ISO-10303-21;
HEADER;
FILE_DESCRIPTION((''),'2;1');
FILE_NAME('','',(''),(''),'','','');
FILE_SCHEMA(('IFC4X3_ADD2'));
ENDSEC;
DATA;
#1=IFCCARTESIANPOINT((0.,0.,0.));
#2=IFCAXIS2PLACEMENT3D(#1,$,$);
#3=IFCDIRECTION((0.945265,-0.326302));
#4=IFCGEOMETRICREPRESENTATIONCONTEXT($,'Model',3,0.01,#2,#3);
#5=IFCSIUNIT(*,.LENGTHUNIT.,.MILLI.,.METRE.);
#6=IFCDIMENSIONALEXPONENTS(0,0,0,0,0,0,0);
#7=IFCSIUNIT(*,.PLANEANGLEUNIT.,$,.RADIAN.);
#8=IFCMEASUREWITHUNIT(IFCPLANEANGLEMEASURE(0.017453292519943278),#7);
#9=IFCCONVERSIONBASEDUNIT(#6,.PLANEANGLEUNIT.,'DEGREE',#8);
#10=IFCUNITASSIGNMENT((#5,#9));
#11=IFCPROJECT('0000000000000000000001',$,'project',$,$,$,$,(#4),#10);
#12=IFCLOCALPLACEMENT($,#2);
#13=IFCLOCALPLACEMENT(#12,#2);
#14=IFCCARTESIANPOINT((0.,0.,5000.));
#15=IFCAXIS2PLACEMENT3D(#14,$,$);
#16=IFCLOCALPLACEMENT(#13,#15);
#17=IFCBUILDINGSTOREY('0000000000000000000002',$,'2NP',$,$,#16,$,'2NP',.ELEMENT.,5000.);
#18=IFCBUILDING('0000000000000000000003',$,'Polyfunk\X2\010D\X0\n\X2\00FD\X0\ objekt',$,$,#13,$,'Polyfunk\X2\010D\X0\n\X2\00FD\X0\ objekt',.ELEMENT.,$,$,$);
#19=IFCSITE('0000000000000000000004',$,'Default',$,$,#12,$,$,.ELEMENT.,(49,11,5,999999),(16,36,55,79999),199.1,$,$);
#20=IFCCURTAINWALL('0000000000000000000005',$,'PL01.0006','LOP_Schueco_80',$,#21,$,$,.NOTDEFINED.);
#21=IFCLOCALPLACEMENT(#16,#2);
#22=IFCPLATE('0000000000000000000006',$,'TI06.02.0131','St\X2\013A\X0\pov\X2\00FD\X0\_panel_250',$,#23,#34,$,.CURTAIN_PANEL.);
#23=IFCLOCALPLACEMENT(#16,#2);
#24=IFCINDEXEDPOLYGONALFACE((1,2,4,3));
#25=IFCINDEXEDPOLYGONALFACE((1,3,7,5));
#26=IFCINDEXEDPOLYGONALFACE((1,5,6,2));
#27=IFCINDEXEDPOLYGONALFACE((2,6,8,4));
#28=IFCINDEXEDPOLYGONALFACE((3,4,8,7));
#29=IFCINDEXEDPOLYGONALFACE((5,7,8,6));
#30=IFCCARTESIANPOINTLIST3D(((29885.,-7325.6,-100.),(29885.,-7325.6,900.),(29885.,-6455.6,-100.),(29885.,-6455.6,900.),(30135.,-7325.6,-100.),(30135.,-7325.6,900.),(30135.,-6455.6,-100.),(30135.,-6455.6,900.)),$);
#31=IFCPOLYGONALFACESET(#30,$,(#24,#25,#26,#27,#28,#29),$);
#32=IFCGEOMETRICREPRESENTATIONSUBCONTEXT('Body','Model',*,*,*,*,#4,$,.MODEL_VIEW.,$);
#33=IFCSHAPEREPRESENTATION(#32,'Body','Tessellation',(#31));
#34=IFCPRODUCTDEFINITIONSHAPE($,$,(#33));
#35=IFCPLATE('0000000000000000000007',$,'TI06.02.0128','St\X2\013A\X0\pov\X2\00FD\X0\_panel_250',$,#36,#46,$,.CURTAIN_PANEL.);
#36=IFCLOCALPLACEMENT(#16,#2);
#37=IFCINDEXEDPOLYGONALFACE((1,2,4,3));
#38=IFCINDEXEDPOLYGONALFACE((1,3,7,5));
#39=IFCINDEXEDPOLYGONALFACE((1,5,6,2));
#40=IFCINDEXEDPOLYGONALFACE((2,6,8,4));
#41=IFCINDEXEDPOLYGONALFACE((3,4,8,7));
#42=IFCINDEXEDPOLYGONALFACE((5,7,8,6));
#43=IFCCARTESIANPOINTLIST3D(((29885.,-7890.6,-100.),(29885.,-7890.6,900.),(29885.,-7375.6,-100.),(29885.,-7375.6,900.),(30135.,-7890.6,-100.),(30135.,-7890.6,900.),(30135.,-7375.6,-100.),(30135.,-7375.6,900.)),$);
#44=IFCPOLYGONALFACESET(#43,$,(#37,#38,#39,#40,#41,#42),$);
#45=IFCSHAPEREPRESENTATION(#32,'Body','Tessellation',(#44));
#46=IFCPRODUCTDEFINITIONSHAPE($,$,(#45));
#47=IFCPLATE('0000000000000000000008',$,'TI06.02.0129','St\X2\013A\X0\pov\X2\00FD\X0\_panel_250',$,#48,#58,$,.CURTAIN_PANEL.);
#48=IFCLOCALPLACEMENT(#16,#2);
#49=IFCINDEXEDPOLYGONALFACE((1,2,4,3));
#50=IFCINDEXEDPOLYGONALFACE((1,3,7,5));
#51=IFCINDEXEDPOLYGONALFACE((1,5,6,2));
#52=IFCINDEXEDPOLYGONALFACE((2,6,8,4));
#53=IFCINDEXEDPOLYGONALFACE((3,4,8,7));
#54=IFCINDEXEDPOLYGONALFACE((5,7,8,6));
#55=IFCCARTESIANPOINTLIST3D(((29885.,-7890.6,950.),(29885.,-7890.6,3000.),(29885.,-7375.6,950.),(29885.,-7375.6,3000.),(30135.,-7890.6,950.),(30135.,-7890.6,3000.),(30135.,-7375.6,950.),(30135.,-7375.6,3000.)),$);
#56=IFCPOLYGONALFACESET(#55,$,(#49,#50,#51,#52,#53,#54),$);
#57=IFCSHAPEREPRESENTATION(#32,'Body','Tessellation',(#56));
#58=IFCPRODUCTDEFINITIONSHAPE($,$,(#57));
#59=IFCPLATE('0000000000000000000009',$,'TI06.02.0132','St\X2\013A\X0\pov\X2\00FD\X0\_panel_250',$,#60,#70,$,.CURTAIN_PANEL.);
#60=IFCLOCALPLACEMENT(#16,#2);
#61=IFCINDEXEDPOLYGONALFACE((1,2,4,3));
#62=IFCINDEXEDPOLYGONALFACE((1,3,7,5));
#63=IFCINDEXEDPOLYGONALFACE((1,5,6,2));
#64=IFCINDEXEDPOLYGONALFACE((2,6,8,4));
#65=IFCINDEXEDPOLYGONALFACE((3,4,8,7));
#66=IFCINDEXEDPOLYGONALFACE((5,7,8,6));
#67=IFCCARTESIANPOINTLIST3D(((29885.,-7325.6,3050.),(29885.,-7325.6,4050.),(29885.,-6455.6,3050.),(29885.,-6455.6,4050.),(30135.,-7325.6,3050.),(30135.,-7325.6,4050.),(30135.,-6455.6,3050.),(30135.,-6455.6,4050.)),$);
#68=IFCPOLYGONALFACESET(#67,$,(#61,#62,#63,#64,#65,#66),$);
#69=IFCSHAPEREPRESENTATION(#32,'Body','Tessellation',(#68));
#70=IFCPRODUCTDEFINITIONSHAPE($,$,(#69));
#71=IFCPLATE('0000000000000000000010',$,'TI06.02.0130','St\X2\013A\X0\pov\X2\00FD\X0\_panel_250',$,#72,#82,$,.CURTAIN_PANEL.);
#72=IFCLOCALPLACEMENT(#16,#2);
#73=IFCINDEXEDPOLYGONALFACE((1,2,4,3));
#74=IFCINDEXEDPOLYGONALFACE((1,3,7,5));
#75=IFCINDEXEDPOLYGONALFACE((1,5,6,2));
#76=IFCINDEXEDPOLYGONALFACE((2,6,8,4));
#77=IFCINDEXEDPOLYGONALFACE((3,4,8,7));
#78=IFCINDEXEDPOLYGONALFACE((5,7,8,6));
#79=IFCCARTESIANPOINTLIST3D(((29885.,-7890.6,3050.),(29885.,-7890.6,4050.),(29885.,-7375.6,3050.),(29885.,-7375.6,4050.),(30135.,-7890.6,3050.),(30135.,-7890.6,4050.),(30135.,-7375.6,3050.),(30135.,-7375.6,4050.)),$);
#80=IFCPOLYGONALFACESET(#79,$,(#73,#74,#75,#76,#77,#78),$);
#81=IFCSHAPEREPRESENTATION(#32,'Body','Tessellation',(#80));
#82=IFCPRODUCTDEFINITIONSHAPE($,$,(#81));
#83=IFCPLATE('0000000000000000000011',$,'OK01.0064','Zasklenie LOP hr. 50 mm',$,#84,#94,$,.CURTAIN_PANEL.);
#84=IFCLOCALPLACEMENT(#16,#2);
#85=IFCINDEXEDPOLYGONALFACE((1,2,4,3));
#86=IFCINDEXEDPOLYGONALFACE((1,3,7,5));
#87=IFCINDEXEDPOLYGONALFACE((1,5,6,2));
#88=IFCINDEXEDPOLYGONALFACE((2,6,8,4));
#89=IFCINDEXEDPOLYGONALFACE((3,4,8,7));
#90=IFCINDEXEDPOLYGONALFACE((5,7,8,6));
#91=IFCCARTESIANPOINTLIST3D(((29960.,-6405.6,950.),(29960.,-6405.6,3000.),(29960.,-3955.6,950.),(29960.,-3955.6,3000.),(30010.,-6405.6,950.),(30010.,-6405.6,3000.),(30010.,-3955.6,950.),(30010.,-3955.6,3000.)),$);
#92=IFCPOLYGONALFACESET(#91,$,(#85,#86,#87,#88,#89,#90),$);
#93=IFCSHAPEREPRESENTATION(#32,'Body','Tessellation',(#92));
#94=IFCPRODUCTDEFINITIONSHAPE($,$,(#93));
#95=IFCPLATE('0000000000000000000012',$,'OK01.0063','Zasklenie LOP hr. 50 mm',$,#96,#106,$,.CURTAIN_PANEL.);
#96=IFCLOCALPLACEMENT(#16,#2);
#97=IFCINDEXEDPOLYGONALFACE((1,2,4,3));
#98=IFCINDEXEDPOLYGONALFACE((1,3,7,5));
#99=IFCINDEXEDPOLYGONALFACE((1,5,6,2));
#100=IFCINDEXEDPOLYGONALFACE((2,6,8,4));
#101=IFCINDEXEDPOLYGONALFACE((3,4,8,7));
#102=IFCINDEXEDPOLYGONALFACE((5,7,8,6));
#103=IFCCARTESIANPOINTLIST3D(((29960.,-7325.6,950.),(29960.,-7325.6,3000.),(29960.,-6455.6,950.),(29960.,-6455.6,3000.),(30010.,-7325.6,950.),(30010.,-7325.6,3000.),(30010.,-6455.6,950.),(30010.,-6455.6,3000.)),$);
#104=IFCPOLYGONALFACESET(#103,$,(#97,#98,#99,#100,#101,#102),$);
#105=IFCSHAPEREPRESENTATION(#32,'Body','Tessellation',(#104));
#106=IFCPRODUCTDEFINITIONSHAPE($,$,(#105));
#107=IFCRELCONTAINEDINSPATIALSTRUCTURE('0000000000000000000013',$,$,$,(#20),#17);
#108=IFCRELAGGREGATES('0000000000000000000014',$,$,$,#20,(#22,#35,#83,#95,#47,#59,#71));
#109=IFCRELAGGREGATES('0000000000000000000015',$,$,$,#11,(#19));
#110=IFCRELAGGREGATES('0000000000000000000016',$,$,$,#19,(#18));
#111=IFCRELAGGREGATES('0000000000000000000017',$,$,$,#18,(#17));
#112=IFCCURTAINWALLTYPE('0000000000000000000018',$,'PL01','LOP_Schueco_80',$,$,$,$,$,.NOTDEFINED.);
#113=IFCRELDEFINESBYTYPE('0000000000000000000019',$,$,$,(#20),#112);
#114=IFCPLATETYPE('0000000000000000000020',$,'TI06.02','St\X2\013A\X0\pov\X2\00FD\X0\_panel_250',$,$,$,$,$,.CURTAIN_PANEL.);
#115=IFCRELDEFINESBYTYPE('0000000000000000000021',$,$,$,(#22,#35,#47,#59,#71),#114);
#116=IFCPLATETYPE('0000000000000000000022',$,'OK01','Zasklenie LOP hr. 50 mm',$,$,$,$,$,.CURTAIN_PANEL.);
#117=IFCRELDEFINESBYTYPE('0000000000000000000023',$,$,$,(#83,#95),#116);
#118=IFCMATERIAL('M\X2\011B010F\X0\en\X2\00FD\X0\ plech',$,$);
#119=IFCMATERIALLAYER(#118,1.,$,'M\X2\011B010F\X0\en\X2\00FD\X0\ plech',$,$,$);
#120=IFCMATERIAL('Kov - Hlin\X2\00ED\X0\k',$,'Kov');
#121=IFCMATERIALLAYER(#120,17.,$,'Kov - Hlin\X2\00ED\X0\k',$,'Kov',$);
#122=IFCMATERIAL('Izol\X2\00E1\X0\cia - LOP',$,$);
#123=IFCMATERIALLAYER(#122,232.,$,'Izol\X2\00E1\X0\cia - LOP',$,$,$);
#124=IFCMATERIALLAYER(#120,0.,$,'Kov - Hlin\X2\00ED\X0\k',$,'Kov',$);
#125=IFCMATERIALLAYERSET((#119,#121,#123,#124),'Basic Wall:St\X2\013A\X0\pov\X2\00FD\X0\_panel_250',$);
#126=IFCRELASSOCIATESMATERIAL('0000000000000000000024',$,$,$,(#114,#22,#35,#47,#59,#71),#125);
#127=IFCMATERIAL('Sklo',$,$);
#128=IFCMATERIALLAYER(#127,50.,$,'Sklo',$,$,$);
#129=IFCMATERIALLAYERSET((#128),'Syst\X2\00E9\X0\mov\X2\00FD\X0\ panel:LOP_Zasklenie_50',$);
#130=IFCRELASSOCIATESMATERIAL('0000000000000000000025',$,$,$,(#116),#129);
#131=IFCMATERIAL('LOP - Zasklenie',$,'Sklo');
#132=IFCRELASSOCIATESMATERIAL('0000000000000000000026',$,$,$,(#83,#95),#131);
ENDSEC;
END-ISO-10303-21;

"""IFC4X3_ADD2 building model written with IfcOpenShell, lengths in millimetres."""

from ifc_helpers import new_model, entity, si_unit, converted_unit, direction, frame, frame_2d, origin, origin_2d_with_axis, place, context, subcontext, project, spatial, rectangle, extrude, source, transform, mapped, material, layer, layer_set, layer_usage, type_object, type_shapes, element, aggregate, save


model = new_model("IFC4X3_ADD2")

# Units and contexts
model_context = context("Model", 3, precision=0.01, world=origin(), true_north=direction((0.945265, -0.326302)))
body_context = subcontext(model_context, "Body", "Model", "MODEL_VIEW")
ifc_project = project(units=[si_unit("LENGTHUNIT", "METRE", prefix="MILLI"), converted_unit("PLANEANGLEUNIT", "DEGREE", entity("IfcPlaneAngleMeasure", 0.017453292519943278), si_unit("PLANEANGLEUNIT", "RADIAN"), dimensions=[0, 0, 0, 0, 0, 0, 0])], contexts=[model_context])

# Site, building, storey
site_placement = place(None, origin())
site = spatial("IfcSite", under=ifc_project, at=site_placement, Name="Default", CompositionType="ELEMENT", RefLatitude=(49, 11, 5, 999999), RefLongitude=(16, 36, 55, 79999), RefElevation=199.1)
building_placement = place(site_placement, origin())
building = spatial("IfcBuilding", under=site, at=building_placement, Name="Polyfunkčný objekt", LongName="Polyfunkčný objekt", CompositionType="ELEMENT")
storey_placement = place(building_placement, frame((0.0, 0.0, 5000.0)))
storey = spatial("IfcBuildingStorey", under=building, at=storey_placement, Name="2NP", LongName="2NP", CompositionType="ELEMENT", Elevation=5000.0)

# Curtain wall, plates
curtain_wall_type = type_object("IfcCurtainWallType", Name="PL01", Description="LOP_Schueco_80", PredefinedType="NOTDEFINED")
curtain_wall_placement = place(storey_placement, frame((0.0, 0.0, -5000.0)))
curtain_wall = element("IfcCurtainWall", 1, at=curtain_wall_placement, inside=storey, type_object=curtain_wall_type, Name="PL01.0006", Description="LOP_Schueco_80", PredefinedType="NOTDEFINED")
ifc_material_1 = material(Name="Měďený plech")
ifc_layer_1 = layer(ifc_material_1, 1.0, Name="Měďený plech")
ifc_material_2 = material(Name="Kov - Hliník", Category="Kov")
ifc_layer_2 = layer(ifc_material_2, 17.0, Name="Kov - Hliník", Category="Kov")
ifc_material_3 = material(Name="Izolácia - LOP")
ifc_layer_3 = layer(ifc_material_3, 232.0, Name="Izolácia - LOP")
ifc_layer_4 = layer(ifc_material_2, 0.0, Name="Kov - Hliník", Category="Kov")
ifc_layer_set_1 = layer_set([ifc_layer_1, ifc_layer_2, ifc_layer_3, ifc_layer_4], Name="Basic Wall:Stĺpový_panel_250")
ifc_layer_usage_1 = layer_usage(ifc_layer_set_1, "AXIS2", "POSITIVE", -125.0)
plate_type_1 = type_object("IfcPlateType", Name="TI06.02", Description="Stĺpový_panel_250", PredefinedType="CURTAIN_PANEL", material=ifc_layer_set_1)
plate_1_placement = place(storey_placement, frame((30010.0, -6455.6, -100.0), z_axis=(0.0, 0.0, 1.0), x_axis=(0.0, -1.0, 0.0)))
plate_1 = element("IfcPlate", 2, at=plate_1_placement, type_object=plate_type_1, material=ifc_layer_usage_1, Name="TI06.02.0131", Description="Stĺpový_panel_250", PredefinedType="CURTAIN_PANEL", context=body_context, shape_type="SweptSolid", body=[
    extrude(rectangle(XDim=250.0, YDim=870.0, at=frame_2d((0.0, 0.0), x_axis=(1.0, 0.0))), frame((435.0, 0.0, 0.0), z_axis=(0.0, 0.0, 1.0), x_axis=(0.0, 1.0, 0.0)), (0.0, 0.0, 1.0), 1000.0),
])
ifc_layer_usage_2 = layer_usage(ifc_layer_set_1, "AXIS2", "POSITIVE", -125.0)
plate_2_placement = place(storey_placement, frame((30010.0, -7375.6, -100.0), z_axis=(0.0, 0.0, 1.0), x_axis=(0.0, -1.0, 0.0)))
plate_2 = element("IfcPlate", 3, at=plate_2_placement, type_object=plate_type_1, material=ifc_layer_usage_2, Name="TI06.02.0128", Description="Stĺpový_panel_250", PredefinedType="CURTAIN_PANEL", context=body_context, shape_type="SweptSolid", body=[
    extrude(rectangle(XDim=250.0, YDim=515.0, at=frame_2d((0.0, 0.0), x_axis=(1.0, 0.0))), frame((257.5, 0.0, 0.0), z_axis=(0.0, 0.0, 1.0), x_axis=(0.0, 1.0, 0.0)), (0.0, 0.0, 1.0), 1000.0),
])
ifc_layer_usage_3 = layer_usage(ifc_layer_set_1, "AXIS2", "POSITIVE", -125.0)
plate_3_placement = place(storey_placement, frame((30010.0, -7375.6, 950.0), z_axis=(0.0, 0.0, 1.0), x_axis=(0.0, -1.0, 0.0)))
plate_3 = element("IfcPlate", 4, at=plate_3_placement, type_object=plate_type_1, material=ifc_layer_usage_3, Name="TI06.02.0129", Description="Stĺpový_panel_250", PredefinedType="CURTAIN_PANEL", context=body_context, shape_type="SweptSolid", body=[
    extrude(rectangle(XDim=250.0, YDim=515.0, at=frame_2d((0.0, 0.0), x_axis=(1.0, 0.0))), frame((257.5, 0.0, 0.0), z_axis=(0.0, 0.0, 1.0), x_axis=(0.0, 1.0, 0.0)), (0.0, 0.0, 1.0), 2050.0),
])
ifc_layer_usage_4 = layer_usage(ifc_layer_set_1, "AXIS2", "POSITIVE", -125.0)
plate_4_placement = place(storey_placement, frame((30010.0, -6455.6, 3050.0), z_axis=(0.0, 0.0, 1.0), x_axis=(0.0, -1.0, 0.0)))
plate_4 = element("IfcPlate", 5, at=plate_4_placement, type_object=plate_type_1, material=ifc_layer_usage_4, Name="TI06.02.0132", Description="Stĺpový_panel_250", PredefinedType="CURTAIN_PANEL", context=body_context, shape_type="SweptSolid", body=[
    extrude(rectangle(XDim=250.0, YDim=870.0, at=frame_2d((0.0, 0.0), x_axis=(1.0, 0.0))), frame((435.0, 0.0, 0.0), z_axis=(0.0, 0.0, 1.0), x_axis=(0.0, 1.0, 0.0)), (0.0, 0.0, 1.0), 1000.0),
])
ifc_layer_usage_5 = layer_usage(ifc_layer_set_1, "AXIS2", "POSITIVE", -125.0)
plate_5_placement = place(storey_placement, frame((30010.0, -7375.6, 3050.0), z_axis=(0.0, 0.0, 1.0), x_axis=(0.0, -1.0, 0.0)))
plate_5 = element("IfcPlate", 6, at=plate_5_placement, type_object=plate_type_1, material=ifc_layer_usage_5, Name="TI06.02.0130", Description="Stĺpový_panel_250", PredefinedType="CURTAIN_PANEL", context=body_context, shape_type="SweptSolid", body=[
    extrude(rectangle(XDim=250.0, YDim=515.0, at=frame_2d((0.0, 0.0), x_axis=(1.0, 0.0))), frame((257.5, 0.0, 0.0), z_axis=(0.0, 0.0, 1.0), x_axis=(0.0, 1.0, 0.0)), (0.0, 0.0, 1.0), 1000.0),
])
ifc_material_4 = material(Name="LOP - Zasklenie", Category="Sklo")
ifc_material_5 = material(Name="Sklo")
ifc_layer_5 = layer(ifc_material_5, 50.0, Name="Sklo")
ifc_layer_set_2 = layer_set([ifc_layer_5], Name="Systémový panel:LOP_Zasklenie_50")
plate_type_2 = type_object("IfcPlateType", Name="OK01", Description="Zasklenie LOP hr. 50 mm", PredefinedType="CURTAIN_PANEL", material=ifc_layer_set_2)
shared_shape_1 = source(origin(), body_context, "Body", "SweptSolid", [
    extrude(rectangle(XDim=50.0, YDim=2450.0, at=origin_2d_with_axis()), frame((0.0, -25.0, 0.0), z_axis=(0.0, 0.0, 1.0), x_axis=(0.0, 1.0, 0.0)), (0.0, 0.0, 1.0), 2050.0),
])
plate_6_placement = place(curtain_wall_placement, frame((30010.0, -5180.6, 5950.0), z_axis=(0.0, 0.0, 1.0), x_axis=(0.0, -1.0, 0.0)))
plate_6 = element("IfcPlate", 7, at=plate_6_placement, type_object=plate_type_2, material=ifc_material_4, Name="OK01.0064", Description="Zasklenie LOP hr. 50 mm", PredefinedType="CURTAIN_PANEL", context=body_context, shape_type="MappedRepresentation", body=[
    mapped(shared_shape_1, transform((0.0, 0.0, 0.0), scale=1.0)),
])
shared_shape_2 = source(origin(), body_context, "Body", "SweptSolid", [
    extrude(rectangle(XDim=50.0, YDim=870.0, at=origin_2d_with_axis()), frame((0.0, -25.0, 0.0), z_axis=(0.0, 0.0, 1.0), x_axis=(0.0, 1.0, 0.0)), (0.0, 0.0, 1.0), 2050.0),
])
type_shapes(plate_type_2, [shared_shape_1, shared_shape_2])
plate_7_placement = place(curtain_wall_placement, frame((30010.0, -6890.6, 5950.0), z_axis=(0.0, 0.0, 1.0), x_axis=(0.0, -1.0, 0.0)))
plate_7 = element("IfcPlate", 8, at=plate_7_placement, type_object=plate_type_2, material=ifc_material_4, Name="OK01.0063", Description="Zasklenie LOP hr. 50 mm", PredefinedType="CURTAIN_PANEL", context=body_context, shape_type="MappedRepresentation", body=[
    mapped(shared_shape_2, transform((0.0, 0.0, 0.0), scale=1.0)),
])
aggregate(curtain_wall, [plate_1, plate_2, plate_6, plate_7, plate_3, plate_4, plate_5])

save(model, "model.ifc")
